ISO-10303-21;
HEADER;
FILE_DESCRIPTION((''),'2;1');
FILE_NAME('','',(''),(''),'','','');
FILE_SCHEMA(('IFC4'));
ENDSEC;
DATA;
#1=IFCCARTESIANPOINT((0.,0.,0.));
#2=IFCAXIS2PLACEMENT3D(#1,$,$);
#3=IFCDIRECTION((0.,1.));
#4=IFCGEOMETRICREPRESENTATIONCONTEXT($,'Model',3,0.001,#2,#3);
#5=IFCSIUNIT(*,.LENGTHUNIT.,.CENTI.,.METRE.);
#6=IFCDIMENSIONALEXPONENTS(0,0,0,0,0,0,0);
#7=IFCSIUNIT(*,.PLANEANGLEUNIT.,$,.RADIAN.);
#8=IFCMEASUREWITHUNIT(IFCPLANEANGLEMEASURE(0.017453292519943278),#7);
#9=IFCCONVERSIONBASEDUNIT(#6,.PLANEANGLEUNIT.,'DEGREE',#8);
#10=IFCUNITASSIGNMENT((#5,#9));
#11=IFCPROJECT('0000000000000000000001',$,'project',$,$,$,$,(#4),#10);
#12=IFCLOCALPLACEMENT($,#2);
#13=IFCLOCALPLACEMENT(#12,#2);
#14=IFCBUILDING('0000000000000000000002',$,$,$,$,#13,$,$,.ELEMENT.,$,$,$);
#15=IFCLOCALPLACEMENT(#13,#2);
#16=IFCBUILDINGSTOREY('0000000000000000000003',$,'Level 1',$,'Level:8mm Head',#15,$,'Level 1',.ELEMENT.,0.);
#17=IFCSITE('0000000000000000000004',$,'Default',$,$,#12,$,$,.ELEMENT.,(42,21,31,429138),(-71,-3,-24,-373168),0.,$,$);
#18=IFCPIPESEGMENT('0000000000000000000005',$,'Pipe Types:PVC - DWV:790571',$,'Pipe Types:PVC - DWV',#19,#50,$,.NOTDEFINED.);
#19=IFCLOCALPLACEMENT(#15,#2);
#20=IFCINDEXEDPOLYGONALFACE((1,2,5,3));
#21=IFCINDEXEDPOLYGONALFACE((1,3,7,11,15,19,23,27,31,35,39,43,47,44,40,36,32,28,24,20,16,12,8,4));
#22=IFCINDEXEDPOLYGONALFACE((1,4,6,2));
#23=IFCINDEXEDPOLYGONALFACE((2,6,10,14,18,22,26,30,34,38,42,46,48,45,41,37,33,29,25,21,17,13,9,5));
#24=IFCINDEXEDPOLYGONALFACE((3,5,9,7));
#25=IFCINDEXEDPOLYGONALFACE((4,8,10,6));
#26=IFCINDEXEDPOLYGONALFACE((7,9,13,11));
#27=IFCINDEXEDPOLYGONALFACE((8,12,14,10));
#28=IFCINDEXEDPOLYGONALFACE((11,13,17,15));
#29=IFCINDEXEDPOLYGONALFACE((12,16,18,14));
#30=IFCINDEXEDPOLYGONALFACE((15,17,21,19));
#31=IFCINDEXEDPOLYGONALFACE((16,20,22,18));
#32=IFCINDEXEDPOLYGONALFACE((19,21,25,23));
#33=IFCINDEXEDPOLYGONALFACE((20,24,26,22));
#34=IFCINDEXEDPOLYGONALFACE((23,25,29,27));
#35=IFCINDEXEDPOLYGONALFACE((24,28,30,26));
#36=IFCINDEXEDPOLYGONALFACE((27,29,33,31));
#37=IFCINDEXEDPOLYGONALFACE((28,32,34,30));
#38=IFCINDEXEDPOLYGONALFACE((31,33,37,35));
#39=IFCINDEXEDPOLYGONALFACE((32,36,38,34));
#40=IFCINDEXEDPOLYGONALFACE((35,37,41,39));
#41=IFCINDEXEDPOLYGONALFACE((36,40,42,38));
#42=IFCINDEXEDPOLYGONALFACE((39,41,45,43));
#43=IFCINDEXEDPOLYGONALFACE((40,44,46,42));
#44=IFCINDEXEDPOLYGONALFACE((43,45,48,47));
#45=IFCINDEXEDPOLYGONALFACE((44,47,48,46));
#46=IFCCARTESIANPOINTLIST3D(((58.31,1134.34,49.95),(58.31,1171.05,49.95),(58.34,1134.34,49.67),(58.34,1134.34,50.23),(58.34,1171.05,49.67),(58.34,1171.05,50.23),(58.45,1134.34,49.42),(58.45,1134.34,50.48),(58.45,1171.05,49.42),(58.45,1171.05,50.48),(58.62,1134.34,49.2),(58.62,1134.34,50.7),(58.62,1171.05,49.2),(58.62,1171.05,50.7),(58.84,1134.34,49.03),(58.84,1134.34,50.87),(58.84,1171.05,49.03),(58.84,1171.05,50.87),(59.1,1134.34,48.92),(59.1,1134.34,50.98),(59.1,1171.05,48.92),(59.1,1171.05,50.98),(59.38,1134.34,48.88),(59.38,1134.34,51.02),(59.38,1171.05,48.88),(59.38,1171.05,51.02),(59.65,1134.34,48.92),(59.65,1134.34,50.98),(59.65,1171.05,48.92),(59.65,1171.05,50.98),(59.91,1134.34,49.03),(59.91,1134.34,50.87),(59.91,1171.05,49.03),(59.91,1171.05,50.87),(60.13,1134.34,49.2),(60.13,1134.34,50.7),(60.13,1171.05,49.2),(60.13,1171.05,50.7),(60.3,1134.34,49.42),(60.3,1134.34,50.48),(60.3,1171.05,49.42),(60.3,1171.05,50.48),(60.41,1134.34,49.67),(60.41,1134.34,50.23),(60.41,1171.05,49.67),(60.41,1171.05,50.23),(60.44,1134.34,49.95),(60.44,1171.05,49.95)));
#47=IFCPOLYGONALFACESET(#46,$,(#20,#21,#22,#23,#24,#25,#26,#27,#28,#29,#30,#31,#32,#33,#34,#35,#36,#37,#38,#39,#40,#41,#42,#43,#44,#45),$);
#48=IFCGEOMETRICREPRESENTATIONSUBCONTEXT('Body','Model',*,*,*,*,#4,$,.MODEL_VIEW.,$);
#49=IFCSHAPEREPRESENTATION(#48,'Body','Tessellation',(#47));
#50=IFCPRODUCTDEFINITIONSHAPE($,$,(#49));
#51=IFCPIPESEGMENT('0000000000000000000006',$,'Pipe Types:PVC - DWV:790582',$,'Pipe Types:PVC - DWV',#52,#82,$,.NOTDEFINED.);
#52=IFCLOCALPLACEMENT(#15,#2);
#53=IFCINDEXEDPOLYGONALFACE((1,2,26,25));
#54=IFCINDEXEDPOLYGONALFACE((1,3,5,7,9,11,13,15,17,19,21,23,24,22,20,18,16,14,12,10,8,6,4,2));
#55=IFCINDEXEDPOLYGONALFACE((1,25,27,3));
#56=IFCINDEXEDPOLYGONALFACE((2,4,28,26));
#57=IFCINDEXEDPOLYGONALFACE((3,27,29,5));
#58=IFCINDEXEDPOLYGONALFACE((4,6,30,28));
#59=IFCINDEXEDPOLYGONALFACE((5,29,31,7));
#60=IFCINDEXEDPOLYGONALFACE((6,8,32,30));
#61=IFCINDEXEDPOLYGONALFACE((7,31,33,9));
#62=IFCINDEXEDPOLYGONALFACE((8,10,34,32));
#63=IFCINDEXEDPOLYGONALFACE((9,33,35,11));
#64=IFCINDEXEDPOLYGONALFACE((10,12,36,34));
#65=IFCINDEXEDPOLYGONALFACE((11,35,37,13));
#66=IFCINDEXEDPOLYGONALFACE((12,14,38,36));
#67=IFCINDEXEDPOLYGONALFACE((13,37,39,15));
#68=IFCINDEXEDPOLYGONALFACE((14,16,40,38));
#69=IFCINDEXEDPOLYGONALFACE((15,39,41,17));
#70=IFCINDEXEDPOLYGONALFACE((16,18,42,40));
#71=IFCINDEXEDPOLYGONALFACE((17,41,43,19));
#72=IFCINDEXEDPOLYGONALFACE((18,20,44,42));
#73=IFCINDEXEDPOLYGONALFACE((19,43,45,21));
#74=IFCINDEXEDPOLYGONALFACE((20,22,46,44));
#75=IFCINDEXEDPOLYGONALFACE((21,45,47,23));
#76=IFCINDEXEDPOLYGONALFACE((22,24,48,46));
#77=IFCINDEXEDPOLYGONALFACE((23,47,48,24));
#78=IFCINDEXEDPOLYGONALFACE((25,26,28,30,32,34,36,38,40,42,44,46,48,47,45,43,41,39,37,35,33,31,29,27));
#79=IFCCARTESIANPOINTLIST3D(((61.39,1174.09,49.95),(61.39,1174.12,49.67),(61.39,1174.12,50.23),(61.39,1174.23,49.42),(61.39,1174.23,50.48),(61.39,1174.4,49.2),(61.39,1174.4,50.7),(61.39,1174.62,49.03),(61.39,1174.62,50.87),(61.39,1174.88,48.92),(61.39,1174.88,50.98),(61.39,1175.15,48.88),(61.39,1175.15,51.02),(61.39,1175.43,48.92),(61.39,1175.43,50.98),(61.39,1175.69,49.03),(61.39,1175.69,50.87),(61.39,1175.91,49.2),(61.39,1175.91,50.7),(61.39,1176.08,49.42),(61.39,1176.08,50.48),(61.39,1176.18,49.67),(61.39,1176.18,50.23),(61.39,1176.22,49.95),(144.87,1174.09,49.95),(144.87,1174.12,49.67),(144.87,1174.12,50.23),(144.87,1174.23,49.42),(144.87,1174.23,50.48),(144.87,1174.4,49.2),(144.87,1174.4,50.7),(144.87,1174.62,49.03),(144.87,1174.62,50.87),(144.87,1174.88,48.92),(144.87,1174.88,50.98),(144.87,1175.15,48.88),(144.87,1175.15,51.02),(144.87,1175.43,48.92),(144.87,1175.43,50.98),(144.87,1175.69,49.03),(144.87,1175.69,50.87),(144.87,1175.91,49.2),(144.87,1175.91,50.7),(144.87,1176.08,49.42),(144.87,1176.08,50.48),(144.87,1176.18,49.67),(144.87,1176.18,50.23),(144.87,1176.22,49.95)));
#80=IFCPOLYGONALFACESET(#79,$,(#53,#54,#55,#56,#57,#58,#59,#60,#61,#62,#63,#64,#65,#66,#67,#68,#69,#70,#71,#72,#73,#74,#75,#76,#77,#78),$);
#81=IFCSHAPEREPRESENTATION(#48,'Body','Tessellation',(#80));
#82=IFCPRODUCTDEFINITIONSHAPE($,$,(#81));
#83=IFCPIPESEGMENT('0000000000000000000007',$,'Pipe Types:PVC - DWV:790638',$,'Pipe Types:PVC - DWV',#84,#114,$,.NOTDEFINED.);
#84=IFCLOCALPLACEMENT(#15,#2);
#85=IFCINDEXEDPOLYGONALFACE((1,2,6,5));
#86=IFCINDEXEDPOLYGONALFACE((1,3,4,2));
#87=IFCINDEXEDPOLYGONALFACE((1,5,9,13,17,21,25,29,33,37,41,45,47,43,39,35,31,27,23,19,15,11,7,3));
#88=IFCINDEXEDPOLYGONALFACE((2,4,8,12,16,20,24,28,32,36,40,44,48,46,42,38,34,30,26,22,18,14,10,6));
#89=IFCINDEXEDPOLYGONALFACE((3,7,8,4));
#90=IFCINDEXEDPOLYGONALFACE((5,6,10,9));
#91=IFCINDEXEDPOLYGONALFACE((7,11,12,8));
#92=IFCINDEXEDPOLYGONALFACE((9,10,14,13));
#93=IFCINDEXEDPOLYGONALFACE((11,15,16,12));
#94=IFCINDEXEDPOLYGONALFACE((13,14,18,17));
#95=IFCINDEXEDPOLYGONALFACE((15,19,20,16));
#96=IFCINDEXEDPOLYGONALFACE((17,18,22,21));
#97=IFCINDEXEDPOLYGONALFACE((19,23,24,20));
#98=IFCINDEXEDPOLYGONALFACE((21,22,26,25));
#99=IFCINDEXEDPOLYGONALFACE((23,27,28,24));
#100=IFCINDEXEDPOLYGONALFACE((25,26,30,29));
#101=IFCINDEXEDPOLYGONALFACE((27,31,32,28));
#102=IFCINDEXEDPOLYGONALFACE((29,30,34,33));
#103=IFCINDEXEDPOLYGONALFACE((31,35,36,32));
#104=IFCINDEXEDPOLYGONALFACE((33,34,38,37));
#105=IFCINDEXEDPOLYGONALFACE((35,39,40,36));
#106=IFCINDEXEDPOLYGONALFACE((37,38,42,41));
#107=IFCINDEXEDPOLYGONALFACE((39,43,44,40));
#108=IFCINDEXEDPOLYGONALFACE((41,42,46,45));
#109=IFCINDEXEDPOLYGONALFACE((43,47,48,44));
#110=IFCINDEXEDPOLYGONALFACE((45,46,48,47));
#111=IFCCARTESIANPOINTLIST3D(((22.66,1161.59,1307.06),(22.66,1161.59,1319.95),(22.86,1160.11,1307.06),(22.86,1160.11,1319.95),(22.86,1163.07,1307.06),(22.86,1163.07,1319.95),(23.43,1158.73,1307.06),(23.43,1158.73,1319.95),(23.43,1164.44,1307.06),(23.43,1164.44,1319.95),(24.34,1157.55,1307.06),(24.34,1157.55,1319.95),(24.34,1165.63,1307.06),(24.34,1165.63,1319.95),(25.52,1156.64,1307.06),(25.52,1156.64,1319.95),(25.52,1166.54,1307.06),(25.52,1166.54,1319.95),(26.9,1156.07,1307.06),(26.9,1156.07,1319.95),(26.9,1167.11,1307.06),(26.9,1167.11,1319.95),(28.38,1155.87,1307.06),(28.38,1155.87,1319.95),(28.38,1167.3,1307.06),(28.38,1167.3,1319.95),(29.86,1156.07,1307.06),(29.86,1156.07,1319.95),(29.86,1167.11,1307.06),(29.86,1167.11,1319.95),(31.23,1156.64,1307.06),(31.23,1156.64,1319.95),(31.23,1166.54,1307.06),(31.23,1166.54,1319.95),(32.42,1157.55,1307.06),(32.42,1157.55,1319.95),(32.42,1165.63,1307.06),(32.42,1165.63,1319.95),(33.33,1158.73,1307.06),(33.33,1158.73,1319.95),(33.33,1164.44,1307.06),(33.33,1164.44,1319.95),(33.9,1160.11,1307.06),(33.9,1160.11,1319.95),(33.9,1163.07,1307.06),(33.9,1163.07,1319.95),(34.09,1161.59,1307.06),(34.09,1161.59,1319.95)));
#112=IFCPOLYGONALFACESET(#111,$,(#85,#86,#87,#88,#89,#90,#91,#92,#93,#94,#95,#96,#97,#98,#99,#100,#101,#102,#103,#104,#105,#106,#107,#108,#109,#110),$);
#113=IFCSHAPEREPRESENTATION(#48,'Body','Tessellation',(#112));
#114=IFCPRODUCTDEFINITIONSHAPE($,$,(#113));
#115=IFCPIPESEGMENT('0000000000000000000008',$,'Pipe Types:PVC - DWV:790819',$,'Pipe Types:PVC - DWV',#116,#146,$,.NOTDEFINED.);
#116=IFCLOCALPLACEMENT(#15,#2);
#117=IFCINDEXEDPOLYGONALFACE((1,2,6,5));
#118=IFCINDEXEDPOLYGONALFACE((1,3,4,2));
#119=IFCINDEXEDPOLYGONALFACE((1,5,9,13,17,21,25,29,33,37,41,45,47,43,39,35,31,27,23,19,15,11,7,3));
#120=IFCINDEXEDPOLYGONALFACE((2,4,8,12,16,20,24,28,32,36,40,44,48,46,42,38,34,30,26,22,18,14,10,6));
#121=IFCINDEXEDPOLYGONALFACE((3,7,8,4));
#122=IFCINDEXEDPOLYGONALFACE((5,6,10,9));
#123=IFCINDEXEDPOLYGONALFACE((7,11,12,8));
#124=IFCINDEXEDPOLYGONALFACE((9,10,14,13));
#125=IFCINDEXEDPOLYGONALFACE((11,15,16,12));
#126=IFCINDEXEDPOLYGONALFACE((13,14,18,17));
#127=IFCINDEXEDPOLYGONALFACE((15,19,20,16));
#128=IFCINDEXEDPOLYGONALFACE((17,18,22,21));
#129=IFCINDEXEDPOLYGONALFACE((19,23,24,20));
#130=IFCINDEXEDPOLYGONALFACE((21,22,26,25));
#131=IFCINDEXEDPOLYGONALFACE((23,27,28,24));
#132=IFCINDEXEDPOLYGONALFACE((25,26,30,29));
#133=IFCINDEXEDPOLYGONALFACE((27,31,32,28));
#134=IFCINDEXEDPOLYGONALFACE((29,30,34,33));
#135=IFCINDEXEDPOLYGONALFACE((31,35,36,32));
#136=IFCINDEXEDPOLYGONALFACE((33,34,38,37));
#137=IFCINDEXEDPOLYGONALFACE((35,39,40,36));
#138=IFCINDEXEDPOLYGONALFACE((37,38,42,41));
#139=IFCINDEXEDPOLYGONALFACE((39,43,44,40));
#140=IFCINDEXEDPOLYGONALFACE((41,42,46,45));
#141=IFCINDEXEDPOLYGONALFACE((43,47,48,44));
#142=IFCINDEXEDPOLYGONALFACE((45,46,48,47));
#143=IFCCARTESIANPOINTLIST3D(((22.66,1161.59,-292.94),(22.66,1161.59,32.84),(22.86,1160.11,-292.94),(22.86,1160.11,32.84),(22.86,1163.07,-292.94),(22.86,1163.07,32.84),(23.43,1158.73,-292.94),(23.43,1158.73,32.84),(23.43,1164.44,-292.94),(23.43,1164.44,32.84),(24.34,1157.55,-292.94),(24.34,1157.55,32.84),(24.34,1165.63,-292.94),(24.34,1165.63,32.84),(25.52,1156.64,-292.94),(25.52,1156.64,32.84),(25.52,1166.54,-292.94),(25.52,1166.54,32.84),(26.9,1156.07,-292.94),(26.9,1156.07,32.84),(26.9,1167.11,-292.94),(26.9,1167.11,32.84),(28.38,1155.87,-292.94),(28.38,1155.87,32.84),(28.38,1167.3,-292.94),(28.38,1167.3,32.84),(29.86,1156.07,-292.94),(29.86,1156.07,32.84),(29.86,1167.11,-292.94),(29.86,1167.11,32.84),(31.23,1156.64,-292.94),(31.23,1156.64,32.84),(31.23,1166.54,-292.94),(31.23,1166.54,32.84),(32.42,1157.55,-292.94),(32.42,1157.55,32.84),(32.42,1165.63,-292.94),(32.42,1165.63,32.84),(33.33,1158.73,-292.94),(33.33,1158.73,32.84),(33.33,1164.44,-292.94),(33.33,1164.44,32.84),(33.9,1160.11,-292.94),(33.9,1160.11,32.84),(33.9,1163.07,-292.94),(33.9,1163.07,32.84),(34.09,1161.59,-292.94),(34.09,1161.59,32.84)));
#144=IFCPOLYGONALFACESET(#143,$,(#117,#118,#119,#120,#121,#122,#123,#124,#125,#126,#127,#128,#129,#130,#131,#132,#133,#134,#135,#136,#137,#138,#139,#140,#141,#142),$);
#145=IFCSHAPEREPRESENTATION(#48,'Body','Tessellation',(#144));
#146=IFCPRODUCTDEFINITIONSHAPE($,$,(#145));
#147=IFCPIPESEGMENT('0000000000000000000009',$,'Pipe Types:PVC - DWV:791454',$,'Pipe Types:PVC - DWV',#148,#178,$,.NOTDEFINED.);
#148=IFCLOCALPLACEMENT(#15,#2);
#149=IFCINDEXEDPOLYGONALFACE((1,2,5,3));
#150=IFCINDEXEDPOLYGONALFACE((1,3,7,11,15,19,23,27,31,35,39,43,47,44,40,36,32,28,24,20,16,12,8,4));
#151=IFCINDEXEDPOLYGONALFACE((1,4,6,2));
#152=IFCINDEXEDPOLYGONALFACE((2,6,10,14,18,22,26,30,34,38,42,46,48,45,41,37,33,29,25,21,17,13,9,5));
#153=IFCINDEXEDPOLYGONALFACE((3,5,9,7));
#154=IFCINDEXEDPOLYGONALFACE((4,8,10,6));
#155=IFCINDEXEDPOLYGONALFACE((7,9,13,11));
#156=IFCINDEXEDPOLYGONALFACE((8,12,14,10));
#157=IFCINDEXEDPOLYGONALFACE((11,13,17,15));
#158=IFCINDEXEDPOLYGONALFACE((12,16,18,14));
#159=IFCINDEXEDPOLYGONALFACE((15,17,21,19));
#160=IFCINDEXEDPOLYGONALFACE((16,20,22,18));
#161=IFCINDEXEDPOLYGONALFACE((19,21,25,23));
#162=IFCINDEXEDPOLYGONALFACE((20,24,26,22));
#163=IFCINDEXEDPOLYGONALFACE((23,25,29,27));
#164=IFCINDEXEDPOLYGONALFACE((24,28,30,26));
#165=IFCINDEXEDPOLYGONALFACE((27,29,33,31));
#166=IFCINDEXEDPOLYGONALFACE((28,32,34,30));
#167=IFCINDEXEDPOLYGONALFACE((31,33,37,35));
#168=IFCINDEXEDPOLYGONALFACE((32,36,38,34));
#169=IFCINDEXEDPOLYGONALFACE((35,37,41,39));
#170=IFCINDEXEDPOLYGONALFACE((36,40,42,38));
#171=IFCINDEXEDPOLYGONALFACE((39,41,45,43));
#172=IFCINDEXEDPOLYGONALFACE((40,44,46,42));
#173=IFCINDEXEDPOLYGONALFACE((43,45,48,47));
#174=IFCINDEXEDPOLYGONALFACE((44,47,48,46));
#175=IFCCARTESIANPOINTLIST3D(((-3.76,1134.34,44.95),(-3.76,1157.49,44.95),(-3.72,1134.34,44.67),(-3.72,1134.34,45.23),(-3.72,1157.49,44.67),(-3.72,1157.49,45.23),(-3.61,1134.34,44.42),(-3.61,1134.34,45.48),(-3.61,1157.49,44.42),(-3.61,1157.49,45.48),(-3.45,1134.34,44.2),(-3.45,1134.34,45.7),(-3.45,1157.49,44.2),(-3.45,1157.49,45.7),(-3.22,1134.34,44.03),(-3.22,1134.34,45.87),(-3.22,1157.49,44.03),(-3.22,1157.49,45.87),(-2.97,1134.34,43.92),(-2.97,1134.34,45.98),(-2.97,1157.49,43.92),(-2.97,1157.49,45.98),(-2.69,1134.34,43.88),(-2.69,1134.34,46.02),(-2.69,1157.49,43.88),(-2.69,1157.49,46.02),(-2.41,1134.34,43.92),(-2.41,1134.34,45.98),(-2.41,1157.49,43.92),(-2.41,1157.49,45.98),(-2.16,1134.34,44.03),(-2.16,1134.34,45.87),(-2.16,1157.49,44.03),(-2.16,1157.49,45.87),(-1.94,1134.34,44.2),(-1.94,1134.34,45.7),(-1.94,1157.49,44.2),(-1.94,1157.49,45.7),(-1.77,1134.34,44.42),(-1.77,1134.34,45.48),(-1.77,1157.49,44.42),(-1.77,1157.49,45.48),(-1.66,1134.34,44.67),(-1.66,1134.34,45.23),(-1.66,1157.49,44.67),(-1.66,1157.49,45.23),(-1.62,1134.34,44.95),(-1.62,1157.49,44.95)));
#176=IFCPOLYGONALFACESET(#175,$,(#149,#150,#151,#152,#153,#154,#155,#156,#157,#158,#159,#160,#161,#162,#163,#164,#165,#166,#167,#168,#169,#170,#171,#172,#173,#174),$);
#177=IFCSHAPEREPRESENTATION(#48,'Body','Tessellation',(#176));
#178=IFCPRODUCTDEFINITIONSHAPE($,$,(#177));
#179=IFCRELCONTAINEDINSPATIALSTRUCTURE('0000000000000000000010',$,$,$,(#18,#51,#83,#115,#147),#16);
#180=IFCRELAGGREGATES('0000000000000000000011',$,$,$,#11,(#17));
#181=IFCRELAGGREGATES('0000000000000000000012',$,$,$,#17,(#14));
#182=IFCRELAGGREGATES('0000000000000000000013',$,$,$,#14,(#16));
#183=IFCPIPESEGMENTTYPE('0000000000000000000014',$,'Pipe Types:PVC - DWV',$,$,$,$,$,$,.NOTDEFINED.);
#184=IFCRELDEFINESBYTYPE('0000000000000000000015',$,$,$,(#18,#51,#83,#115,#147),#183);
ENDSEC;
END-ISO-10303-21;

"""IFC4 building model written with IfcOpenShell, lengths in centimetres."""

from ifc_helpers import new_model, entity, si_unit, converted_unit, direction, frame, origin, place, context, subcontext, project, spatial, arc, indexed_curve, outline, extrude, type_object, element, save


model = new_model("IFC4")

# Units and contexts
model_context = context("Model", 3, precision=0.001, world=origin(), true_north=direction((0.0, 1.0)))
body_context = subcontext(model_context, "Body", "Model", "MODEL_VIEW")
ifc_project = project(units=[si_unit("LENGTHUNIT", "METRE", prefix="CENTI"), converted_unit("PLANEANGLEUNIT", "DEGREE", entity("IfcPlaneAngleMeasure", 0.017453292519943278), si_unit("PLANEANGLEUNIT", "RADIAN"), dimensions=[0, 0, 0, 0, 0, 0, 0])], contexts=[model_context])

# Site, building, storey
site_placement = place(None, origin())
site = spatial("IfcSite", under=ifc_project, at=site_placement, Name="Default", CompositionType="ELEMENT", RefLatitude=(42, 21, 31, 429138), RefLongitude=(-71, -3, -24, -373168), RefElevation=0.0)
building_placement = place(site_placement, origin())
building = spatial("IfcBuilding", under=site, at=building_placement, CompositionType="ELEMENT")
storey_placement = place(building_placement, origin())
storey = spatial("IfcBuildingStorey", under=building, at=storey_placement, Name="Level 1", ObjectType="Level:8mm Head", LongName="Level 1", CompositionType="ELEMENT", Elevation=0.0)

# Pipe segments
pipe_segment_type = type_object("IfcPipeSegmentType", Name="Pipe Types:PVC - DWV", PredefinedType="NOTDEFINED")
pipe_segment_1_placement = place(storey_placement, origin())
element("IfcPipeSegment", 1, at=pipe_segment_1_placement, inside=storey, type_object=pipe_segment_type, Name="Pipe Types:PVC - DWV:790571", ObjectType="Pipe Types:PVC - DWV", PredefinedType="NOTDEFINED", context=body_context, shape_type="SweptSolid", body=[
    extrude(outline(indexed_curve([(1.07, 0.0), (0.75, 0.75), (0.0, 1.07), (-0.75, 0.75), (-1.07, 0.0), (-0.75, -0.75), (0.0, -1.07), (0.75, -0.75)], segments=[arc(1, 2, 3), arc(3, 4, 5), arc(5, 6, 7), arc(7, 8, 1)], self_intersect=False)), frame((59.38, 1134.34, 49.95), z_axis=(0.0, 1.0, 0.0), x_axis=(-1.0, 0.0, 0.0)), (0.0, 0.0, 1.0), 36.71),
])
pipe_segment_2_placement = place(storey_placement, origin())
element("IfcPipeSegment", 2, at=pipe_segment_2_placement, inside=storey, type_object=pipe_segment_type, Name="Pipe Types:PVC - DWV:790582", ObjectType="Pipe Types:PVC - DWV", PredefinedType="NOTDEFINED", context=body_context, shape_type="SweptSolid", body=[
    extrude(outline(indexed_curve([(1.07, 0.0), (0.75, 0.75), (0.0, 1.07), (-0.75, 0.75), (-1.07, 0.0), (-0.75, -0.75), (0.0, -1.07), (0.75, -0.75)], segments=[arc(1, 2, 3), arc(3, 4, 5), arc(5, 6, 7), arc(7, 8, 1)], self_intersect=False)), frame((61.39, 1175.15, 49.95), z_axis=(1.0, 0.0, 0.0), x_axis=(0.0, 1.0, 0.0)), (0.0, 0.0, 1.0), 83.49),
])
pipe_segment_3_placement = place(storey_placement, origin())
element("IfcPipeSegment", 3, at=pipe_segment_3_placement, inside=storey, type_object=pipe_segment_type, Name="Pipe Types:PVC - DWV:790638", ObjectType="Pipe Types:PVC - DWV", PredefinedType="NOTDEFINED", context=body_context, shape_type="SweptSolid", body=[
    extrude(outline(indexed_curve([(5.72, 0.0), (4.04, 4.04), (0.0, 5.71), (-4.04, 4.04), (-5.71, 0.0), (-4.04, -4.04), (0.0, -5.71), (4.04, -4.04)], segments=[arc(1, 2, 3), arc(3, 4, 5), arc(5, 6, 7), arc(7, 8, 1)], self_intersect=False)), frame((28.38, 1161.59, 1307.06), z_axis=(0.0, 0.0, 1.0), x_axis=(-1.0, 0.0, 0.0)), (0.0, 0.0, 1.0), 12.88),
])
pipe_segment_4_placement = place(storey_placement, origin())
element("IfcPipeSegment", 4, at=pipe_segment_4_placement, inside=storey, type_object=pipe_segment_type, Name="Pipe Types:PVC - DWV:790819", ObjectType="Pipe Types:PVC - DWV", PredefinedType="NOTDEFINED", context=body_context, shape_type="SweptSolid", body=[
    extrude(outline(indexed_curve([(5.72, 0.0), (4.04, 4.04), (0.0, 5.71), (-4.04, 4.04), (-5.71, 0.0), (-4.04, -4.04), (0.0, -5.71), (4.04, -4.04)], segments=[arc(1, 2, 3), arc(3, 4, 5), arc(5, 6, 7), arc(7, 8, 1)], self_intersect=False)), frame((28.38, 1161.59, -292.94), z_axis=(0.0, 0.0, 1.0), x_axis=(-1.0, 0.0, 0.0)), (0.0, 0.0, 1.0), 325.78),
])
pipe_segment_5_placement = place(storey_placement, origin())
element("IfcPipeSegment", 5, at=pipe_segment_5_placement, inside=storey, type_object=pipe_segment_type, Name="Pipe Types:PVC - DWV:791454", ObjectType="Pipe Types:PVC - DWV", PredefinedType="NOTDEFINED", context=body_context, shape_type="SweptSolid", body=[
    extrude(outline(indexed_curve([(1.07, 0.0), (0.75, 0.75), (0.0, 1.07), (-0.75, 0.75), (-1.07, 0.0), (-0.75, -0.75), (0.0, -1.07), (0.75, -0.75)], segments=[arc(1, 2, 3), arc(3, 4, 5), arc(5, 6, 7), arc(7, 8, 1)], self_intersect=False)), frame((-2.69, 1134.34, 44.95), z_axis=(0.0, 1.0, 0.0), x_axis=(1.0, 0.0, 0.0)), (0.0, 0.0, 1.0), 23.14),
])

save(model, "model.ifc")
